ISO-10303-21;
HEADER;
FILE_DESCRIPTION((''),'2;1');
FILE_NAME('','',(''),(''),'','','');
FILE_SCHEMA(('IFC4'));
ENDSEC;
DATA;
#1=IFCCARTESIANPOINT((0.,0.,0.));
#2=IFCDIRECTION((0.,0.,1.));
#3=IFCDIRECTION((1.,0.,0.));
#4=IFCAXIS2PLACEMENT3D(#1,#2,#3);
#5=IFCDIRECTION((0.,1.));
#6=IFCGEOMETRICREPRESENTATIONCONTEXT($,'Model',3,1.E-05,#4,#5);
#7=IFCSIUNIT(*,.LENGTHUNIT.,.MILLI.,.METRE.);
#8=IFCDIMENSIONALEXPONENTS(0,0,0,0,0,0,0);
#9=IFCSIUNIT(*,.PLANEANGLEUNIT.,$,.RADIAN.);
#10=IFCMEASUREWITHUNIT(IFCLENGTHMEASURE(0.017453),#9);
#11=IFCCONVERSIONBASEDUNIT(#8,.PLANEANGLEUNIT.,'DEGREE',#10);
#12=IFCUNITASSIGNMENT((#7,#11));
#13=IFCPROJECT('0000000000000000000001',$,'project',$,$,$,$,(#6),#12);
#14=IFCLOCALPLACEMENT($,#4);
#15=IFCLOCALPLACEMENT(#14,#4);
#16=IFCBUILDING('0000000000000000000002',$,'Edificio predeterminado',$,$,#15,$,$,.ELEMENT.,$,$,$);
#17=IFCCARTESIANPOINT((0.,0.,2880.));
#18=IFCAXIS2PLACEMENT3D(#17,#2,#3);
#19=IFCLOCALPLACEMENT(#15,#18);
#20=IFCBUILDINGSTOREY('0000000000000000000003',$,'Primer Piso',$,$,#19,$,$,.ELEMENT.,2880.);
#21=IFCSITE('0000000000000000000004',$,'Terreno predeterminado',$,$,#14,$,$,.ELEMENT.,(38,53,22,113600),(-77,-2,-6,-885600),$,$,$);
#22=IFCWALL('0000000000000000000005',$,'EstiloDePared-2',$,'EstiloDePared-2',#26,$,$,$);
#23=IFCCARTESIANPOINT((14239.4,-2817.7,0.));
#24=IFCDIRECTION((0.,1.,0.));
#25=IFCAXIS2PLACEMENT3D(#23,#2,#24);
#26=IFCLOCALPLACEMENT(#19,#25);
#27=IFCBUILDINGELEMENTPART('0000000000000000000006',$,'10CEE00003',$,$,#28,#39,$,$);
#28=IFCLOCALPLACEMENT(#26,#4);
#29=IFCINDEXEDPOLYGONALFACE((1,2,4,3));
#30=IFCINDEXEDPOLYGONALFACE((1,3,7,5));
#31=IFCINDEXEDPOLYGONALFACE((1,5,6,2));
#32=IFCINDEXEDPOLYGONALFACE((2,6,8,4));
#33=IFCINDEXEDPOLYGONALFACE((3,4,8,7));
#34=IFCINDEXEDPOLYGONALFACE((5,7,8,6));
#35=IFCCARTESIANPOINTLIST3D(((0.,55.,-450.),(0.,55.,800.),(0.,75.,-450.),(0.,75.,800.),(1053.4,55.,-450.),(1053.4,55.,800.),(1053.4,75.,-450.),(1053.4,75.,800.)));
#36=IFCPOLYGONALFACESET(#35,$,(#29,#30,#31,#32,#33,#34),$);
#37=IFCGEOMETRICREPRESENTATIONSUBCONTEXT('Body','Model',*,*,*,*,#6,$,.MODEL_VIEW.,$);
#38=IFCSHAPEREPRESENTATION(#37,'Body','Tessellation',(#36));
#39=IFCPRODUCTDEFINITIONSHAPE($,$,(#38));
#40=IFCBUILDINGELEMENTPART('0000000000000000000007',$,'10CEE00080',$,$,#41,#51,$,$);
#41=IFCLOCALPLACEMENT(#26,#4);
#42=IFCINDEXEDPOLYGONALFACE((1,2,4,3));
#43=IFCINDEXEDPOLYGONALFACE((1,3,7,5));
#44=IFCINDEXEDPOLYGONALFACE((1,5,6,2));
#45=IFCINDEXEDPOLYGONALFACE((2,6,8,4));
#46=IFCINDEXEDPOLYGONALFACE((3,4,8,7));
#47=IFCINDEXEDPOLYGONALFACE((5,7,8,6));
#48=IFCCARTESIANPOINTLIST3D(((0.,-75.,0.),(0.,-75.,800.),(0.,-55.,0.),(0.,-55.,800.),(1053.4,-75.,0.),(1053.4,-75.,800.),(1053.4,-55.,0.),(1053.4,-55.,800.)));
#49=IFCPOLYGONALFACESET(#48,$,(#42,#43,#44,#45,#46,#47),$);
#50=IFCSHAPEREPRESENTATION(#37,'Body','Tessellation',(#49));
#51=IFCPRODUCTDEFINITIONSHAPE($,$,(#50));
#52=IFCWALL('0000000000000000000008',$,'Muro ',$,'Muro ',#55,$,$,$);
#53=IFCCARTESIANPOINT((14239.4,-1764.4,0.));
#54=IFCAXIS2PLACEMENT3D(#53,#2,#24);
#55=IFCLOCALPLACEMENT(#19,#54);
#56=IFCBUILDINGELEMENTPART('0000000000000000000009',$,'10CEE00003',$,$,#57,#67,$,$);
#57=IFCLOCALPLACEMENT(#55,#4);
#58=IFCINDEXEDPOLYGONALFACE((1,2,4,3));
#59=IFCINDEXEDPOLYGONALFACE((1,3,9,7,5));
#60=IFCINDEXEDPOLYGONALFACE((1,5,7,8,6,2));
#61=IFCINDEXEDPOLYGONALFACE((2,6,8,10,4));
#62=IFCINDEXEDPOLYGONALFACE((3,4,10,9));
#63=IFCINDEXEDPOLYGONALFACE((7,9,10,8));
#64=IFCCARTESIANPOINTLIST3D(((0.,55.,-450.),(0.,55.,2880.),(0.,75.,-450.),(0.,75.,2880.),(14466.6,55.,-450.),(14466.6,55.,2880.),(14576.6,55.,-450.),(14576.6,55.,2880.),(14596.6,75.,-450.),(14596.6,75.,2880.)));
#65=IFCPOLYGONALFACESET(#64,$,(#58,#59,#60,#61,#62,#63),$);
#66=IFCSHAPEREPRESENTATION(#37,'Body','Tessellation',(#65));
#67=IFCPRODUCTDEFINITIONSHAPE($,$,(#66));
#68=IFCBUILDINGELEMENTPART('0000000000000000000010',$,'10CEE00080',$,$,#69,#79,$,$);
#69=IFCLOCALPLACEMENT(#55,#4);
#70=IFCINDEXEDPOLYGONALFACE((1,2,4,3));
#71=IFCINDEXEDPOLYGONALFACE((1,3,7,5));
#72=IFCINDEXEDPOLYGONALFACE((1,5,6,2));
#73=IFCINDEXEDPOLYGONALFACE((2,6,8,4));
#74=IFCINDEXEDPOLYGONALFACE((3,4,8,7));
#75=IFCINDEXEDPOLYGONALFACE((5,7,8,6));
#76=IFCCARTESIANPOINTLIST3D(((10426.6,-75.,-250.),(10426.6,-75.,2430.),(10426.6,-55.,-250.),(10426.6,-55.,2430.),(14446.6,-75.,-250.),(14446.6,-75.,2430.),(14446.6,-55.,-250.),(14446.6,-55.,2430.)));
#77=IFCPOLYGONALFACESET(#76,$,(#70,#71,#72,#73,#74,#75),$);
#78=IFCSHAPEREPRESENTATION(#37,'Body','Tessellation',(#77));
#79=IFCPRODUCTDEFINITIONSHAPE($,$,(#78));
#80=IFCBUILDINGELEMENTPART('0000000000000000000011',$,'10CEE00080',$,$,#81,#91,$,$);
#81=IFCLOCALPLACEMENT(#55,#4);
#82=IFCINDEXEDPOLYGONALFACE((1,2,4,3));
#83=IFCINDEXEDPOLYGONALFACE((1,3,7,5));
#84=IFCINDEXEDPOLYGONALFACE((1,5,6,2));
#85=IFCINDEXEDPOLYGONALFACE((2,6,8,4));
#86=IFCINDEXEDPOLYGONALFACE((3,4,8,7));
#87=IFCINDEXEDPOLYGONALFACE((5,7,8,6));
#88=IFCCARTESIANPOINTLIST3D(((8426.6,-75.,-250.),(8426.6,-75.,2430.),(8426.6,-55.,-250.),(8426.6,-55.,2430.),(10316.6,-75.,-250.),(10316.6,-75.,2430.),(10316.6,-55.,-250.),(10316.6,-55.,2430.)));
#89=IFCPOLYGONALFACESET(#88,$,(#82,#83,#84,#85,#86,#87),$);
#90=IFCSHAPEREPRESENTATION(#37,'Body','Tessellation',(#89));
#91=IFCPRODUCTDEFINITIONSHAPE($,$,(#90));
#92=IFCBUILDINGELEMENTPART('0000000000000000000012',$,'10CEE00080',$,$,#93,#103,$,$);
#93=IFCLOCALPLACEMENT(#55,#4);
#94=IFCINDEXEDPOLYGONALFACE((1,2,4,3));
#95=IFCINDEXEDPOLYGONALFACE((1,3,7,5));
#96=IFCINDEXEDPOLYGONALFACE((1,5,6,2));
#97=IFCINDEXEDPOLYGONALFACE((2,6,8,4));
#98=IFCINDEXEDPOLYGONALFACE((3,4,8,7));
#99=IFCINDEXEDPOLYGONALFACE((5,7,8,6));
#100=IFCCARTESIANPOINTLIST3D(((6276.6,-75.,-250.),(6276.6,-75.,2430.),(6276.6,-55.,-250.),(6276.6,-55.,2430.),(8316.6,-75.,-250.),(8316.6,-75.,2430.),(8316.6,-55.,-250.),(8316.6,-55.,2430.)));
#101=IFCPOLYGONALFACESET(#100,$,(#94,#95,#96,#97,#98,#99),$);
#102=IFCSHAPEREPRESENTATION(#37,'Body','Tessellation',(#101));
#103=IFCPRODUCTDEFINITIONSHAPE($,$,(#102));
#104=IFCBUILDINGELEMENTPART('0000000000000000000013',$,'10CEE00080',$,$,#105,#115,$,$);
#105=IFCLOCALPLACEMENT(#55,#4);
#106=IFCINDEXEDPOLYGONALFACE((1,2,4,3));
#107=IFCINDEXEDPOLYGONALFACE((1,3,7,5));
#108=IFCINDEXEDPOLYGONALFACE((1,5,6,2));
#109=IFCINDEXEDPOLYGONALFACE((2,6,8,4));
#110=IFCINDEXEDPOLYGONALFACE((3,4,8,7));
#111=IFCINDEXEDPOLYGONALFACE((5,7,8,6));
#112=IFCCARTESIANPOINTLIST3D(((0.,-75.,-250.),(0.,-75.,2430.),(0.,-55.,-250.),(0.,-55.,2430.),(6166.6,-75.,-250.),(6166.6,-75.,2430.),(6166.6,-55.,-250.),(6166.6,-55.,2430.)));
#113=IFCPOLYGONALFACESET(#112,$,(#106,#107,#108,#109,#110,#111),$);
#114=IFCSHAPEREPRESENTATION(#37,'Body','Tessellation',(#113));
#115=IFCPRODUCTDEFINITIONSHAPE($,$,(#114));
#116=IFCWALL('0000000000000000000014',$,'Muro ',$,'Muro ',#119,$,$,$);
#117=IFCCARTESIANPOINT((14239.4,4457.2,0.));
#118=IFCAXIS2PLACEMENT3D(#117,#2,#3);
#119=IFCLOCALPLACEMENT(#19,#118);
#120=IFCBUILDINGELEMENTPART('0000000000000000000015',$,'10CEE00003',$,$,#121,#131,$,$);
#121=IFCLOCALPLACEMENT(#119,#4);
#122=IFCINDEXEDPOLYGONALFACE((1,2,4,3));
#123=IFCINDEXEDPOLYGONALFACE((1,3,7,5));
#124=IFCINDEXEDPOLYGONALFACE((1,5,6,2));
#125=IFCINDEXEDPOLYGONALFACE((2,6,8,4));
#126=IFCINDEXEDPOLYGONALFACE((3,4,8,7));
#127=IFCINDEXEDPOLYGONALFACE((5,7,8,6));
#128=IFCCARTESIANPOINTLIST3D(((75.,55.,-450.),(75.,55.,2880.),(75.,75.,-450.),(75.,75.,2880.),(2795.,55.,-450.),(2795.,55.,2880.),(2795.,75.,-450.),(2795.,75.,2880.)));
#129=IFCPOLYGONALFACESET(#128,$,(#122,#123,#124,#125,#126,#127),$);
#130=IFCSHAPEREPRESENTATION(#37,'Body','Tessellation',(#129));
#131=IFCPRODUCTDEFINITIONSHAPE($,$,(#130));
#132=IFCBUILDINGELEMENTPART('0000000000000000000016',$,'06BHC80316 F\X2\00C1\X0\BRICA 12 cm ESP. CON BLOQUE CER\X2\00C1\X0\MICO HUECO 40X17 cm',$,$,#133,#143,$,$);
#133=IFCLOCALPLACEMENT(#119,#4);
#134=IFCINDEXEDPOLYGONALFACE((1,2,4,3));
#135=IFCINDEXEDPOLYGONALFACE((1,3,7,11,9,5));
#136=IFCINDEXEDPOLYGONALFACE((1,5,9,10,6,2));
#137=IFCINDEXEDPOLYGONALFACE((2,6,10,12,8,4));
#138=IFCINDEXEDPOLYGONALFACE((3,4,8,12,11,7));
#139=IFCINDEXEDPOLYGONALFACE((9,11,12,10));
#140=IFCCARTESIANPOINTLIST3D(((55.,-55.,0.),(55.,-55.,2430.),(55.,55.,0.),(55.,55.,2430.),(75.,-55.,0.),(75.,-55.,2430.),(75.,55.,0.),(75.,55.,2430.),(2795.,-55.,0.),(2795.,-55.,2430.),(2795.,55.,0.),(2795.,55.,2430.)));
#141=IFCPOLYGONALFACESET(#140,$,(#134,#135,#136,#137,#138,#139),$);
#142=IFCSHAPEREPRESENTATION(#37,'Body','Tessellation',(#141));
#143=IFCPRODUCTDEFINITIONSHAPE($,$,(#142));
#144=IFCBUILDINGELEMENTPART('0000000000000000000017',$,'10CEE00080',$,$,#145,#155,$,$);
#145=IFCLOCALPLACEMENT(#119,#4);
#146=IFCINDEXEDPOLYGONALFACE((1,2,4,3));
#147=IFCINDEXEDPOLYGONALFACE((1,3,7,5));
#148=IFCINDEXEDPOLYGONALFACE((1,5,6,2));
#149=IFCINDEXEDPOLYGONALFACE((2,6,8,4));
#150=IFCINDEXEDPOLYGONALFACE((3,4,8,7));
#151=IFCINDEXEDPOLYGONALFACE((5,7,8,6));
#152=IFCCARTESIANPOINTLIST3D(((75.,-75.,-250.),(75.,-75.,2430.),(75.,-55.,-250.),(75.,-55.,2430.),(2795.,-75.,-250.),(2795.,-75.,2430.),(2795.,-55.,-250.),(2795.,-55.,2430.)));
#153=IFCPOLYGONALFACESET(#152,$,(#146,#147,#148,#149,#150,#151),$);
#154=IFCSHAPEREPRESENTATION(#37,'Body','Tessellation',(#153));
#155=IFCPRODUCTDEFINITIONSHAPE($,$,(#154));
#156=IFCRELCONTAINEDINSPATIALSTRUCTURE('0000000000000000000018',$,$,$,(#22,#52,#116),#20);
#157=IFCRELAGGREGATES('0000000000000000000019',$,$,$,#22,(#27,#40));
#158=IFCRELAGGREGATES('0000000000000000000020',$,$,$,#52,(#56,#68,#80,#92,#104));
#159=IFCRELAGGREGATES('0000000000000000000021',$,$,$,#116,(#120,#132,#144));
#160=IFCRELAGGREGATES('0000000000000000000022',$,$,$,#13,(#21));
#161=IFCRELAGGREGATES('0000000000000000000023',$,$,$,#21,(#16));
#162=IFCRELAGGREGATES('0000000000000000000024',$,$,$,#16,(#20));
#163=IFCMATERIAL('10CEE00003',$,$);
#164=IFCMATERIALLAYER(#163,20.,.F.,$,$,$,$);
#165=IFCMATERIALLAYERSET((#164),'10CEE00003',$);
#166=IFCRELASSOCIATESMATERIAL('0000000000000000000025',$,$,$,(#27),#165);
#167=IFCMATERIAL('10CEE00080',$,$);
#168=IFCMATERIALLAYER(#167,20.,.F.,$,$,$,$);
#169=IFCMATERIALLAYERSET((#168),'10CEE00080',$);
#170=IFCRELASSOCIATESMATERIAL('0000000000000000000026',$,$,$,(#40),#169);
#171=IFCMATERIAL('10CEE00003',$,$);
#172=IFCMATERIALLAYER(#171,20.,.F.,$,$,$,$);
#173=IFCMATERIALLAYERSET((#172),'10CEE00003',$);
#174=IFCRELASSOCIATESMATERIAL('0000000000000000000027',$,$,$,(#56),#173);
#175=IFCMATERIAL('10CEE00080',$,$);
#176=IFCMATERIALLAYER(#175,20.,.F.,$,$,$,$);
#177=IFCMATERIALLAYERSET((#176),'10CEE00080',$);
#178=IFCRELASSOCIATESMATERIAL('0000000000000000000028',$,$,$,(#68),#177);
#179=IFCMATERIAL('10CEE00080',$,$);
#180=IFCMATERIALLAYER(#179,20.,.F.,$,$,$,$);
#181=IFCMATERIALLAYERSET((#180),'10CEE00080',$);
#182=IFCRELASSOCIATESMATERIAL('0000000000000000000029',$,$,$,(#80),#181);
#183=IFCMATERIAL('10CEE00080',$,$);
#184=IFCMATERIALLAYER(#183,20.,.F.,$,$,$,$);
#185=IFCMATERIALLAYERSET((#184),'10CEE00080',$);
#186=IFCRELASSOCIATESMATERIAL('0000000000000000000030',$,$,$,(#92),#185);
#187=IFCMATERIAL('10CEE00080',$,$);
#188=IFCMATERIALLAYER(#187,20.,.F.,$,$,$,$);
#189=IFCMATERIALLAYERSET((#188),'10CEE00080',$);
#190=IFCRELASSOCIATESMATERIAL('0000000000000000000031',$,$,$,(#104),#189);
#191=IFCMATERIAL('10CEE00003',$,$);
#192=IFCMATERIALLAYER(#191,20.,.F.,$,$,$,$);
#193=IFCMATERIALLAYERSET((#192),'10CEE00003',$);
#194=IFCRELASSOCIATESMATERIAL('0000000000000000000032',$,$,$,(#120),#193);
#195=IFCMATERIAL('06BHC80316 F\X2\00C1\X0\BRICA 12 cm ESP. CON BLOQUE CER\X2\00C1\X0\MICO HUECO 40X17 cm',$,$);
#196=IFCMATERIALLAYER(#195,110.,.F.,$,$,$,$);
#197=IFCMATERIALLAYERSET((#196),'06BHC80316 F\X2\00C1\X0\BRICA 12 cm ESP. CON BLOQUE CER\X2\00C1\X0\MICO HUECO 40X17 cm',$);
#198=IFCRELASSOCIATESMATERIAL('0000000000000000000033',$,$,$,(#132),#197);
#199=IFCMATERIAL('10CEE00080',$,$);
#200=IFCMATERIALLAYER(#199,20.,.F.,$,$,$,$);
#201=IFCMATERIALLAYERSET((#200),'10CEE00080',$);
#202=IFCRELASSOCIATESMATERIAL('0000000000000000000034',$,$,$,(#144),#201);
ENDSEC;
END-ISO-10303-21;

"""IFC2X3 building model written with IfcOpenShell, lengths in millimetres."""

from ifc_helpers import new_model, entity, si_unit, converted_unit, direction, frame, origin_with_axes, place, context, subcontext, project, spatial, polyline, outline, extrude, material, layer, layer_set, layer_usage, element, aggregate, save


model = new_model("IFC2X3")

# Units and contexts
model_context = context("Model", 3, precision=1e-05, world=origin_with_axes(), true_north=direction((0.0, 1.0)))
body_context = subcontext(model_context, "Body", "Model", "MODEL_VIEW")
ifc_project = project(units=[si_unit("LENGTHUNIT", "METRE", prefix="MILLI"), converted_unit("PLANEANGLEUNIT", "DEGREE", entity("IfcLengthMeasure", 0.017453), si_unit("PLANEANGLEUNIT", "RADIAN"), dimensions=[0, 0, 0, 0, 0, 0, 0])], contexts=[model_context])

# Site, building, storey
site_placement = place(None, origin_with_axes())
site = spatial("IfcSite", under=ifc_project, at=site_placement, Name="Terreno predeterminado", CompositionType="ELEMENT", RefLatitude=(38, 53, 22, 113600), RefLongitude=(-77, -2, -6, -885600))
building_placement = place(site_placement, origin_with_axes())
building = spatial("IfcBuilding", under=site, at=building_placement, Name="Edificio predeterminado", CompositionType="ELEMENT")
storey_placement = place(building_placement, frame((0.0, 0.0, 2880.0), z_axis=(0.0, 0.0, 1.0), x_axis=(1.0, 0.0, 0.0)))
storey = spatial("IfcBuildingStorey", under=building, at=storey_placement, Name="Primer Piso", CompositionType="ELEMENT", Elevation=2880.0)

# Walls, building element parts
wall_1_placement = place(storey_placement, frame((14239.4, -2817.7, 0.0), z_axis=(0.0, 0.0, 1.0), x_axis=(0.0, 1.0, 0.0)))
wall_1 = element("IfcWall", 1, at=wall_1_placement, inside=storey, Name="EstiloDePared-2", ObjectType="EstiloDePared-2")
ifc_material_1 = material(Name="10CEE00003")
ifc_layer_1 = layer(ifc_material_1, 20.0, ventilated=False)
ifc_layer_set_1 = layer_set([ifc_layer_1], Name="10CEE00003")
ifc_layer_usage_1 = layer_usage(ifc_layer_set_1, "AXIS2", "NEGATIVE", -75.0)
building_element_part_1_placement = place(wall_1_placement, origin_with_axes())
building_element_part_1 = element("IfcBuildingElementPart", 2, at=building_element_part_1_placement, material=ifc_layer_usage_1, Name="10CEE00003", context=body_context, shape_type="SweptSolid", body=[
    extrude(outline(polyline([(1053.4, 75.0), (1053.4, 55.0), (0.0, 55.0), (0.0, 75.0), (1053.4, 75.0)])), frame((0.0, 0.0, -450.0), z_axis=(0.0, 0.0, 1.0), x_axis=(1.0, 0.0, 0.0)), (0.0, 0.0, 1.0), 1250.0),
])
ifc_material_2 = material(Name="10CEE00080")
ifc_layer_2 = layer(ifc_material_2, 20.0, ventilated=False)
ifc_layer_set_2 = layer_set([ifc_layer_2], Name="10CEE00080")
ifc_layer_usage_2 = layer_usage(ifc_layer_set_2, "AXIS2", "NEGATIVE", 55.0)
building_element_part_2_placement = place(wall_1_placement, origin_with_axes())
building_element_part_2 = element("IfcBuildingElementPart", 3, at=building_element_part_2_placement, material=ifc_layer_usage_2, Name="10CEE00080", context=body_context, shape_type="SweptSolid", body=[
    extrude(outline(polyline([(1053.4, -55.0), (1053.4, -75.0), (0.0, -75.0), (0.0, -55.0), (1053.4, -55.0)])), origin_with_axes(), (0.0, 0.0, 1.0), 800.0),
])
aggregate(wall_1, [building_element_part_1, building_element_part_2])
wall_2_placement = place(storey_placement, frame((14239.4, -1764.4, 0.0), z_axis=(0.0, 0.0, 1.0), x_axis=(0.0, 1.0, 0.0)))
wall_2 = element("IfcWall", 4, at=wall_2_placement, inside=storey, Name="Muro ", ObjectType="Muro ")
ifc_material_3 = material(Name="10CEE00003")
ifc_layer_3 = layer(ifc_material_3, 20.0, ventilated=False)
ifc_layer_set_3 = layer_set([ifc_layer_3], Name="10CEE00003")
ifc_layer_usage_3 = layer_usage(ifc_layer_set_3, "AXIS2", "NEGATIVE", -75.0)
building_element_part_3_placement = place(wall_2_placement, origin_with_axes())
building_element_part_3 = element("IfcBuildingElementPart", 5, at=building_element_part_3_placement, material=ifc_layer_usage_3, Name="10CEE00003", context=body_context, shape_type="SweptSolid", body=[
    extrude(outline(polyline([(14596.6, 75.0), (14576.6, 55.0), (14466.6, 55.0), (0.0, 55.0), (0.0, 75.0), (14596.6, 75.0)])), frame((0.0, 0.0, -450.0), z_axis=(0.0, 0.0, 1.0), x_axis=(1.0, 0.0, 0.0)), (0.0, 0.0, 1.0), 3330.0),
])
ifc_material_4 = material(Name="10CEE00080")
ifc_layer_4 = layer(ifc_material_4, 20.0, ventilated=False)
ifc_layer_set_4 = layer_set([ifc_layer_4], Name="10CEE00080")
ifc_layer_usage_4 = layer_usage(ifc_layer_set_4, "AXIS2", "NEGATIVE", 55.0)
building_element_part_4_placement = place(wall_2_placement, origin_with_axes())
building_element_part_4 = element("IfcBuildingElementPart", 6, at=building_element_part_4_placement, material=ifc_layer_usage_4, Name="10CEE00080", context=body_context, shape_type="SweptSolid", body=[
    extrude(outline(polyline([(14446.6, -55.0), (14446.6, -75.0), (10426.6, -75.0), (10426.6, -55.0), (14446.6, -55.0)])), frame((0.0, 0.0, -250.0), z_axis=(0.0, 0.0, 1.0), x_axis=(1.0, 0.0, 0.0)), (0.0, 0.0, 1.0), 2680.0),
])
ifc_material_5 = material(Name="10CEE00080")
ifc_layer_5 = layer(ifc_material_5, 20.0, ventilated=False)
ifc_layer_set_5 = layer_set([ifc_layer_5], Name="10CEE00080")
ifc_layer_usage_5 = layer_usage(ifc_layer_set_5, "AXIS2", "NEGATIVE", 55.0)
building_element_part_5_placement = place(wall_2_placement, origin_with_axes())
building_element_part_5 = element("IfcBuildingElementPart", 7, at=building_element_part_5_placement, material=ifc_layer_usage_5, Name="10CEE00080", context=body_context, shape_type="SweptSolid", body=[
    extrude(outline(polyline([(10316.6, -55.0), (10316.6, -75.0), (8426.6, -75.0), (8426.6, -55.0), (10316.6, -55.0)])), frame((0.0, 0.0, -250.0), z_axis=(0.0, 0.0, 1.0), x_axis=(1.0, 0.0, 0.0)), (0.0, 0.0, 1.0), 2680.0),
])
ifc_material_6 = material(Name="10CEE00080")
ifc_layer_6 = layer(ifc_material_6, 20.0, ventilated=False)
ifc_layer_set_6 = layer_set([ifc_layer_6], Name="10CEE00080")
ifc_layer_usage_6 = layer_usage(ifc_layer_set_6, "AXIS2", "NEGATIVE", 55.0)
building_element_part_6_placement = place(wall_2_placement, origin_with_axes())
building_element_part_6 = element("IfcBuildingElementPart", 8, at=building_element_part_6_placement, material=ifc_layer_usage_6, Name="10CEE00080", context=body_context, shape_type="SweptSolid", body=[
    extrude(outline(polyline([(8316.6, -55.0), (8316.6, -75.0), (6276.6, -75.0), (6276.6, -55.0), (8316.6, -55.0)])), frame((0.0, 0.0, -250.0), z_axis=(0.0, 0.0, 1.0), x_axis=(1.0, 0.0, 0.0)), (0.0, 0.0, 1.0), 2680.0),
])
ifc_material_7 = material(Name="10CEE00080")
ifc_layer_7 = layer(ifc_material_7, 20.0, ventilated=False)
ifc_layer_set_7 = layer_set([ifc_layer_7], Name="10CEE00080")
ifc_layer_usage_7 = layer_usage(ifc_layer_set_7, "AXIS2", "NEGATIVE", 55.0)
building_element_part_7_placement = place(wall_2_placement, origin_with_axes())
building_element_part_7 = element("IfcBuildingElementPart", 9, at=building_element_part_7_placement, material=ifc_layer_usage_7, Name="10CEE00080", context=body_context, shape_type="SweptSolid", body=[
    extrude(outline(polyline([(6166.6, -55.0), (6166.6, -75.0), (0.0, -75.0), (0.0, -55.0), (6166.6, -55.0)])), frame((0.0, 0.0, -250.0), z_axis=(0.0, 0.0, 1.0), x_axis=(1.0, 0.0, 0.0)), (0.0, 0.0, 1.0), 2680.0),
])
aggregate(wall_2, [building_element_part_3, building_element_part_4, building_element_part_5, building_element_part_6, building_element_part_7])
wall_3_placement = place(storey_placement, frame((14239.4, 4457.2, 0.0), z_axis=(0.0, 0.0, 1.0), x_axis=(1.0, 0.0, 0.0)))
wall_3 = element("IfcWall", 10, at=wall_3_placement, inside=storey, Name="Muro ", ObjectType="Muro ")
ifc_material_8 = material(Name="10CEE00003")
ifc_layer_8 = layer(ifc_material_8, 20.0, ventilated=False)
ifc_layer_set_8 = layer_set([ifc_layer_8], Name="10CEE00003")
ifc_layer_usage_8 = layer_usage(ifc_layer_set_8, "AXIS2", "NEGATIVE", -75.0)
building_element_part_8_placement = place(wall_3_placement, origin_with_axes())
building_element_part_8 = element("IfcBuildingElementPart", 11, at=building_element_part_8_placement, material=ifc_layer_usage_8, Name="10CEE00003", context=body_context, shape_type="SweptSolid", body=[
    extrude(outline(polyline([(2795.0, 75.0), (2795.0, 55.0), (75.0, 55.0), (75.0, 75.0), (2795.0, 75.0)])), frame((0.0, 0.0, -450.0), z_axis=(0.0, 0.0, 1.0), x_axis=(1.0, 0.0, 0.0)), (0.0, 0.0, 1.0), 3330.0),
])
ifc_material_9 = material(Name="06BHC80316 FÁBRICA 12 cm ESP. CON BLOQUE CERÁMICO HUECO 40X17 cm")
ifc_layer_9 = layer(ifc_material_9, 110.0, ventilated=False)
ifc_layer_set_9 = layer_set([ifc_layer_9], Name="06BHC80316 FÁBRICA 12 cm ESP. CON BLOQUE CERÁMICO HUECO 40X17 cm")
ifc_layer_usage_9 = layer_usage(ifc_layer_set_9, "AXIS2", "NEGATIVE", -55.0)
building_element_part_9_placement = place(wall_3_placement, origin_with_axes())
building_element_part_9 = element("IfcBuildingElementPart", 12, at=building_element_part_9_placement, material=ifc_layer_usage_9, Name="06BHC80316 FÁBRICA 12 cm ESP. CON BLOQUE CERÁMICO HUECO 40X17 cm", context=body_context, shape_type="SweptSolid", body=[
    extrude(outline(polyline([(2795.0, 55.0), (2795.0, -55.0), (75.0, -55.0), (55.0, -55.0), (55.0, 55.0), (75.0, 55.0), (2795.0, 55.0)])), origin_with_axes(), (0.0, 0.0, 1.0), 2430.0),
])
ifc_material_10 = material(Name="10CEE00080")
ifc_layer_10 = layer(ifc_material_10, 20.0, ventilated=False)
ifc_layer_set_10 = layer_set([ifc_layer_10], Name="10CEE00080")
ifc_layer_usage_10 = layer_usage(ifc_layer_set_10, "AXIS2", "NEGATIVE", 55.0)
building_element_part_10_placement = place(wall_3_placement, origin_with_axes())
building_element_part_10 = element("IfcBuildingElementPart", 13, at=building_element_part_10_placement, material=ifc_layer_usage_10, Name="10CEE00080", context=body_context, shape_type="SweptSolid", body=[
    extrude(outline(polyline([(75.0, -55.0), (2795.0, -55.0), (2795.0, -75.0), (75.0, -75.0), (75.0, -55.0)])), frame((0.0, 0.0, -250.0), z_axis=(0.0, 0.0, 1.0), x_axis=(1.0, 0.0, 0.0)), (0.0, 0.0, 1.0), 2680.0),
])
aggregate(wall_3, [building_element_part_8, building_element_part_9, building_element_part_10])

save(model, "model.ifc")
